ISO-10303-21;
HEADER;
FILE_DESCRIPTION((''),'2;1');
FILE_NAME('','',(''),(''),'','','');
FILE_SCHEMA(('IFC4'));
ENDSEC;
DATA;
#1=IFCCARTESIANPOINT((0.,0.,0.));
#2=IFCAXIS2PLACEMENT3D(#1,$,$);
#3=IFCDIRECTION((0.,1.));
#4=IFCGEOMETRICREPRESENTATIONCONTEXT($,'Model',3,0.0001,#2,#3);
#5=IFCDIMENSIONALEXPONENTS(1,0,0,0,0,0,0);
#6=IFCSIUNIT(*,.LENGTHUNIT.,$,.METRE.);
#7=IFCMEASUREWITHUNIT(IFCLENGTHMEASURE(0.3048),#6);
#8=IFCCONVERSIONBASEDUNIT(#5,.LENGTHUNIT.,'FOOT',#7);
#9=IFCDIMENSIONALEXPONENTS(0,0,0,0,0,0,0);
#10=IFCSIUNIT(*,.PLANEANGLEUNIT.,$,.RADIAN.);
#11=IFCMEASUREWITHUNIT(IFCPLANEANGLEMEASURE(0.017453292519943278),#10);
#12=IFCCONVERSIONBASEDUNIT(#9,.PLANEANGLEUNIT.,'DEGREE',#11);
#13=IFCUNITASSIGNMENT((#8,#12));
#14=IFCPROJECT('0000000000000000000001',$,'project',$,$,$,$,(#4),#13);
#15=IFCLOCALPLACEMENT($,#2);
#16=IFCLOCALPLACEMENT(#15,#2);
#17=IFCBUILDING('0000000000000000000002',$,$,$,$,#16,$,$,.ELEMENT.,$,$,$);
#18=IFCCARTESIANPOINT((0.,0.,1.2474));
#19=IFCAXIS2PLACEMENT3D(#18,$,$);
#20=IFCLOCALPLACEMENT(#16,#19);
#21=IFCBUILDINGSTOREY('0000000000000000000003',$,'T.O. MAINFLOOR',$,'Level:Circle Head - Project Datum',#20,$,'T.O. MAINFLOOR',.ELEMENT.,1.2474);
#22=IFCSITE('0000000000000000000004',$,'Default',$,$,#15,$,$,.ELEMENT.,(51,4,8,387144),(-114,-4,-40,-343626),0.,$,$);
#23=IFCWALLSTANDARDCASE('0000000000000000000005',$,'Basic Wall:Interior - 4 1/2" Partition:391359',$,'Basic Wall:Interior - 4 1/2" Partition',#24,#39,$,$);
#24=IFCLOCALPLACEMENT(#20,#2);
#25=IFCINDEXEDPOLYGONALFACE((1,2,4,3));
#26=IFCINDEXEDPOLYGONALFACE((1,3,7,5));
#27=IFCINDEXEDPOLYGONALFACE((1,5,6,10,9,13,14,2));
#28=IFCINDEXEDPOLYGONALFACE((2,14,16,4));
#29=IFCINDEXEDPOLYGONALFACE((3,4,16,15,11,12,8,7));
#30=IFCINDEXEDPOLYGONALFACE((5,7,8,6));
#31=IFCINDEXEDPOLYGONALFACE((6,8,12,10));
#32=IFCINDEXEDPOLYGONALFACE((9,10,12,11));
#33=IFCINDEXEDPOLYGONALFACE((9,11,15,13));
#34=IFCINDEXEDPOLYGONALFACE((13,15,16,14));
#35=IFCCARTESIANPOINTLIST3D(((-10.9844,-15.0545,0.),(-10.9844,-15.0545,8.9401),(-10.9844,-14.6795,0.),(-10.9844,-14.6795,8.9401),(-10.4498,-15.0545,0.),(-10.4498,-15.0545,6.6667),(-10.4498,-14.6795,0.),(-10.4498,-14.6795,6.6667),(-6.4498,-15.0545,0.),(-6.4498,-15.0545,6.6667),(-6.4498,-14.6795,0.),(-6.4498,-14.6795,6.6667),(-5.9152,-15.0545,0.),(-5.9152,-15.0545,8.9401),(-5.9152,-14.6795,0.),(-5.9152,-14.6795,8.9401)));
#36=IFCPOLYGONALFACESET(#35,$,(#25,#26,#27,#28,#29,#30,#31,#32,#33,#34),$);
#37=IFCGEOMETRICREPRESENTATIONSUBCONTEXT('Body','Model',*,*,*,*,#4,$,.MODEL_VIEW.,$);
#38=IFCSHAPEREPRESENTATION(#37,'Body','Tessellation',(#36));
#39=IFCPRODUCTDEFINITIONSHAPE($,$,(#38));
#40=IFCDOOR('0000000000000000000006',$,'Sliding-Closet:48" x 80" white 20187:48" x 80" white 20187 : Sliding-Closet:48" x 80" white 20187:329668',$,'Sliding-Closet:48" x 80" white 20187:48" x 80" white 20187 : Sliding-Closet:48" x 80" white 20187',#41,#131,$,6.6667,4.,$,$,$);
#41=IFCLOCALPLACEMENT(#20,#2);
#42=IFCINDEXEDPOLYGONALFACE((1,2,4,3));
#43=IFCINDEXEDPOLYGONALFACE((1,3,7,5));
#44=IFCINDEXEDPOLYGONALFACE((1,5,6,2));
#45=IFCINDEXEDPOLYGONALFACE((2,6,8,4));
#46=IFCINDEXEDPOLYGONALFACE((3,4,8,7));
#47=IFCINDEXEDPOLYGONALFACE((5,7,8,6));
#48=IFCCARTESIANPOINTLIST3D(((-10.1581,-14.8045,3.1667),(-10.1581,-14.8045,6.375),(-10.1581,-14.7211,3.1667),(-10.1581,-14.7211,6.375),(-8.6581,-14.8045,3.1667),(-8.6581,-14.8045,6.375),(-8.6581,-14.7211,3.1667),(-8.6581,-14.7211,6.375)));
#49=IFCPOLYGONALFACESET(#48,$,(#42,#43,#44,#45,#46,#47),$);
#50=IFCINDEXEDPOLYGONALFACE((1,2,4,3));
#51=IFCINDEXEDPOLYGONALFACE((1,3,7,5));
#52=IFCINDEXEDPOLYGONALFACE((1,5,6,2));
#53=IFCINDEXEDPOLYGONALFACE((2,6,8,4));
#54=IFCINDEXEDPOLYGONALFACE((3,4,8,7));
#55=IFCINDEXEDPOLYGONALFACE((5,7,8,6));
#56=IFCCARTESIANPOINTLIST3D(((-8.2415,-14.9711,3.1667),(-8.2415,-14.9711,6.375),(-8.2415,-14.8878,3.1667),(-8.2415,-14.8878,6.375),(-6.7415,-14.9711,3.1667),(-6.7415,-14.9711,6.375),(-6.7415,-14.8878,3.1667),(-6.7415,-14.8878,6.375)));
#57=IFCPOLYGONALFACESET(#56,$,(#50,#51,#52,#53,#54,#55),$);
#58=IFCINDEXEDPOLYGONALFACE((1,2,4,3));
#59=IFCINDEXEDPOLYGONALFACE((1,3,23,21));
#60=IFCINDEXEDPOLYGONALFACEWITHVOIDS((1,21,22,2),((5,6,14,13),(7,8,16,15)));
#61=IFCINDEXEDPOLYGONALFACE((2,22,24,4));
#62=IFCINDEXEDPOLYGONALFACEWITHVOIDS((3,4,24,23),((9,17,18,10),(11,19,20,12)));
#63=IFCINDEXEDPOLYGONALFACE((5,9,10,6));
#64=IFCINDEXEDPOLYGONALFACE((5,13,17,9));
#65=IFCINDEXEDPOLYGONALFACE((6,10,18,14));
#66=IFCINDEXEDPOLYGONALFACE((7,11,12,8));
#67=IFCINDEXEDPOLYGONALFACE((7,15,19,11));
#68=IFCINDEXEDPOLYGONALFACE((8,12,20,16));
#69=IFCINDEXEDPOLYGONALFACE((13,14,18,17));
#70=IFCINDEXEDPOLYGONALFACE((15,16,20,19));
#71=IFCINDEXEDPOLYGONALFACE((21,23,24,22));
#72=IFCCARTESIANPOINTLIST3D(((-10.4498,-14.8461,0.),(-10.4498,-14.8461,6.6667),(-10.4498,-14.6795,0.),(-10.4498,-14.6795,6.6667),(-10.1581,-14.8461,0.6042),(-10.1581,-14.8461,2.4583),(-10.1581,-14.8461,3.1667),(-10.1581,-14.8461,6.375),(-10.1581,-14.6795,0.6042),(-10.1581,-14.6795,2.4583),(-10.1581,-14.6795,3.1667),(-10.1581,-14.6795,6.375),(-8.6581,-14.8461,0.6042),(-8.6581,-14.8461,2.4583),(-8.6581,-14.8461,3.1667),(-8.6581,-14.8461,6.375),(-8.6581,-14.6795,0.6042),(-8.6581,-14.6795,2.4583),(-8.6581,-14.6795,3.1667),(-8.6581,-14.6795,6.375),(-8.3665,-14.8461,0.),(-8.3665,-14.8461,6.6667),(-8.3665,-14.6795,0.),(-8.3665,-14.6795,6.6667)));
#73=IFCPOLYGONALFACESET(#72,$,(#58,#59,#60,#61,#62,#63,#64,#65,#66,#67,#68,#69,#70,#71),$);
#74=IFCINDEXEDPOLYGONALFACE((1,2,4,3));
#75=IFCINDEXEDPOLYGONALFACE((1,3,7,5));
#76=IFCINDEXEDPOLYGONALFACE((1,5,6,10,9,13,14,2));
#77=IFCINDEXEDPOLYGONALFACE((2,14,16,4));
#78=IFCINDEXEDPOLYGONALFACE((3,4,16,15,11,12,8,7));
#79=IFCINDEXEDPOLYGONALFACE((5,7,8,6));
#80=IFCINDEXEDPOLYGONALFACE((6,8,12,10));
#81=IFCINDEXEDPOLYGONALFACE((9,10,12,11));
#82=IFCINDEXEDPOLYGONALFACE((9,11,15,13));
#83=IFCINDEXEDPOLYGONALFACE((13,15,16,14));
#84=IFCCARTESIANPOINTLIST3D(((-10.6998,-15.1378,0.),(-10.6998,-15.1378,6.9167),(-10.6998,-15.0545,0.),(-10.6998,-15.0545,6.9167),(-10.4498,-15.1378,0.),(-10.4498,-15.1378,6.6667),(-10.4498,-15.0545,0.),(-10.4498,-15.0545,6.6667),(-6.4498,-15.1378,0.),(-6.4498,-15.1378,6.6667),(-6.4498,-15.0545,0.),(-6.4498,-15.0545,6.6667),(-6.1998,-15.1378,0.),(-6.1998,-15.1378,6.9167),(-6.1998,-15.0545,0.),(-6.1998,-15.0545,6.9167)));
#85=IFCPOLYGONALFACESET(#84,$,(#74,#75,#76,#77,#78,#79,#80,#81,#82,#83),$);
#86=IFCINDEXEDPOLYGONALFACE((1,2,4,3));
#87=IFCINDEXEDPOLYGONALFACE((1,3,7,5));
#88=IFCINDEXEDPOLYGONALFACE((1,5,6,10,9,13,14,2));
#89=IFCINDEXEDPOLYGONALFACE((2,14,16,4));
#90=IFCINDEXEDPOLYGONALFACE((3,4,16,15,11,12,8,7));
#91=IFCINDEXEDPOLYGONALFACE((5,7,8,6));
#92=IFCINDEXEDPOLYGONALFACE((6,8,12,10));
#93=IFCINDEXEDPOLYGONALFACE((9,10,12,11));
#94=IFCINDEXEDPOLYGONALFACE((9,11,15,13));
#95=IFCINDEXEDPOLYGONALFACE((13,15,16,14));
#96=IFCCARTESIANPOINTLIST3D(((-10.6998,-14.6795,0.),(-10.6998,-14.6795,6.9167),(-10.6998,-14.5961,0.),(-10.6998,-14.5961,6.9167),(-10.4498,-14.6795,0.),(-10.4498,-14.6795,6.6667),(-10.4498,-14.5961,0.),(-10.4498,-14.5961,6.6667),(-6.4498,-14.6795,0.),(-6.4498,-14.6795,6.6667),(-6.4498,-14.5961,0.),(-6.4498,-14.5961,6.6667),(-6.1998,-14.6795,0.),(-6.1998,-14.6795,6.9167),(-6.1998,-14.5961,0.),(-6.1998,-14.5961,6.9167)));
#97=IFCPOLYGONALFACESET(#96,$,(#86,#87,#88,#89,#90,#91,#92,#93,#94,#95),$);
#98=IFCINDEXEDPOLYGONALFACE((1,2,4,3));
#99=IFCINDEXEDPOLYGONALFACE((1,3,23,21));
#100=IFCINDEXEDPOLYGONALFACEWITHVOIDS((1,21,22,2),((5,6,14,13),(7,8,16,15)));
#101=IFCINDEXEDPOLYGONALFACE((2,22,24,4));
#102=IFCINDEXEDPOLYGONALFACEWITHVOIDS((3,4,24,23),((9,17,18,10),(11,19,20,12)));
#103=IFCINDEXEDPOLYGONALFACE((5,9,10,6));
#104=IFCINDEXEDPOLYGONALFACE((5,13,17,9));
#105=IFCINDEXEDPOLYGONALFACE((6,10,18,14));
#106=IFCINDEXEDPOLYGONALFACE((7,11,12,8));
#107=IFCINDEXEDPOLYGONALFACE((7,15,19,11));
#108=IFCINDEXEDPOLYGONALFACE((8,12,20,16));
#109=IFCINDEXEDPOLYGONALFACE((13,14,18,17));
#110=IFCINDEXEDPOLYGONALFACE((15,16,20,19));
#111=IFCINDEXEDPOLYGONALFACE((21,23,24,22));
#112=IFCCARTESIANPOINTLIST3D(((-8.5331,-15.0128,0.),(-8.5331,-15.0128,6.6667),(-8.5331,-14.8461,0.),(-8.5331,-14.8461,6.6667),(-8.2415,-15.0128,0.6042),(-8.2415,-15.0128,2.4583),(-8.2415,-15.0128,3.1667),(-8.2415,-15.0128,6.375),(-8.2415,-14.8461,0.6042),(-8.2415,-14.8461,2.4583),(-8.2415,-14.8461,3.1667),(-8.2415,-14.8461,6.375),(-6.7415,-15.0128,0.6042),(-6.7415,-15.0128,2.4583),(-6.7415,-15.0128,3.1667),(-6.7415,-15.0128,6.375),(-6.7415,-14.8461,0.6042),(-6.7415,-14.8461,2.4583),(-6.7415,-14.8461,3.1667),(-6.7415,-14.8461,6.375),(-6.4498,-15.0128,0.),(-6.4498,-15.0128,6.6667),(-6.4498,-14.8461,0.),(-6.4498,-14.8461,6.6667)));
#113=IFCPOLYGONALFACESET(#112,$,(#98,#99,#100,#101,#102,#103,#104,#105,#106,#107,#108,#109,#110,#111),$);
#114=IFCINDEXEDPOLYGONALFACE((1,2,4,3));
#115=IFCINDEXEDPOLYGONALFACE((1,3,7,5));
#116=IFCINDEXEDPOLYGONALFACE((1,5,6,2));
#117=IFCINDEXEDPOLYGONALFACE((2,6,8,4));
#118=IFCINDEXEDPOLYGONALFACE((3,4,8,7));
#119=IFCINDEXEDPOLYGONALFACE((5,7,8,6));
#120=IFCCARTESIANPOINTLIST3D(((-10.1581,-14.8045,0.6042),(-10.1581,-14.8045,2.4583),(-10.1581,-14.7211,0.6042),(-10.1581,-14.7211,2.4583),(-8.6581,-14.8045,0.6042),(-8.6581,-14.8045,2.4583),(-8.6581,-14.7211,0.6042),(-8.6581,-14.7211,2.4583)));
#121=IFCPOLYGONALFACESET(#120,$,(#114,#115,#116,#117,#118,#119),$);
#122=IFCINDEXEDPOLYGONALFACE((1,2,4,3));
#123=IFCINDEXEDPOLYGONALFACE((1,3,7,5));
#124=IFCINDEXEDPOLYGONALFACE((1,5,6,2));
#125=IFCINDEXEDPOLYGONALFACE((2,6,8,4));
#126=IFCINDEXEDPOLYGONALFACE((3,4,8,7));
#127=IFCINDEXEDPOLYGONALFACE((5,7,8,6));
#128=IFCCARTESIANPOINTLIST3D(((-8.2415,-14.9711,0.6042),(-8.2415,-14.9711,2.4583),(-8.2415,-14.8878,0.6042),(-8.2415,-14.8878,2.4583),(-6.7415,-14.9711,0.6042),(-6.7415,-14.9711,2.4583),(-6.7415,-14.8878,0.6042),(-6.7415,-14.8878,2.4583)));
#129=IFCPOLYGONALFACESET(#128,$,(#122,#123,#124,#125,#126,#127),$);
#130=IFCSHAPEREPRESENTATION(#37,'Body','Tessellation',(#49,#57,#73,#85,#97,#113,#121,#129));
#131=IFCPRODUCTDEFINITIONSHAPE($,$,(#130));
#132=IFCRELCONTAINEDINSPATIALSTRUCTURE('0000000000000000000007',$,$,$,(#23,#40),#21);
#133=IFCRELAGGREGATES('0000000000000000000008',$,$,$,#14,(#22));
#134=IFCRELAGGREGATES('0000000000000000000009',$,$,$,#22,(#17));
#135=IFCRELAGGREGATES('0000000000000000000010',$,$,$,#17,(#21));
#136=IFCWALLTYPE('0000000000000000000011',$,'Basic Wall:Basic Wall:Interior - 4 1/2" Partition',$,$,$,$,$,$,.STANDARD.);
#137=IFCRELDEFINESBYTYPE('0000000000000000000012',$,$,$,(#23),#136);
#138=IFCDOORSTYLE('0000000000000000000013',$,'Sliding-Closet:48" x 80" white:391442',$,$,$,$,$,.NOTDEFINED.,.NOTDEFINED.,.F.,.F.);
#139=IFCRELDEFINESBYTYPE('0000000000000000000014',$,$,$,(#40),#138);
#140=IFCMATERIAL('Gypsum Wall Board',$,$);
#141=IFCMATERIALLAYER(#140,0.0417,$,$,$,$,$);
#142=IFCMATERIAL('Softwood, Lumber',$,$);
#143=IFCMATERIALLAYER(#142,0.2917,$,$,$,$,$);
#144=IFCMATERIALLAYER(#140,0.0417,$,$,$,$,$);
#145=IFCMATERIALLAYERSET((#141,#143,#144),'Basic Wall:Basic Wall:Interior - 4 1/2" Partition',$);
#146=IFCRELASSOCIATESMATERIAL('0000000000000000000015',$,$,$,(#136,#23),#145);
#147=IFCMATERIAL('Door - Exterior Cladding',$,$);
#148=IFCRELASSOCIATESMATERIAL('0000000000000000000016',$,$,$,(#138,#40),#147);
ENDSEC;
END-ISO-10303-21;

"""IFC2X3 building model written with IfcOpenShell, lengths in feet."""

from ifc_helpers import new_model, entity, si_unit, converted_unit, direction, frame, frame_2d, origin, place, context, subcontext, project, spatial, polyline, rectangle, outline, extrude, source, transform, mapped, material, layer, layer_set, layer_usage, type_object, type_shapes, element, fill, save


model = new_model("IFC2X3")

# Units and contexts
model_context = context("Model", 3, precision=0.0001, world=origin(), true_north=direction((0.0, 1.0)))
body_context = subcontext(model_context, "Body", "Model", "MODEL_VIEW")
ifc_project = project(units=[converted_unit("LENGTHUNIT", "FOOT", entity("IfcLengthMeasure", 0.3048), si_unit("LENGTHUNIT", "METRE"), dimensions=[1, 0, 0, 0, 0, 0, 0]), converted_unit("PLANEANGLEUNIT", "DEGREE", entity("IfcPlaneAngleMeasure", 0.017453292519943278), si_unit("PLANEANGLEUNIT", "RADIAN"), dimensions=[0, 0, 0, 0, 0, 0, 0])], contexts=[model_context])

# Site, building, storey
site_placement = place(None, origin())
site = spatial("IfcSite", under=ifc_project, at=site_placement, Name="Default", CompositionType="ELEMENT", RefLatitude=(51, 4, 8, 387144), RefLongitude=(-114, -4, -40, -343626), RefElevation=0.0)
building_placement = place(site_placement, origin())
building = spatial("IfcBuilding", under=site, at=building_placement, CompositionType="ELEMENT")
storey_placement = place(building_placement, frame((0.0, 0.0, 1.2474)))
storey = spatial("IfcBuildingStorey", under=building, at=storey_placement, Name="T.O. MAINFLOOR", ObjectType="Level:Circle Head - Project Datum", LongName="T.O. MAINFLOOR", CompositionType="ELEMENT", Elevation=1.2474)

# Shared definitions
ifc_material_1 = material(Name="Gypsum Wall Board")

# Shared definitions
ifc_material_2 = material(Name="Door - Exterior Cladding")

# Shared definitions
ifc_layer_1 = layer(ifc_material_1, 0.0417)
ifc_material_3 = material(Name="Softwood, Lumber")
ifc_layer_2 = layer(ifc_material_3, 0.2917)
ifc_layer_3 = layer(ifc_material_1, 0.0417)
ifc_layer_set_1 = layer_set([ifc_layer_1, ifc_layer_2, ifc_layer_3], Name="Basic Wall:Basic Wall:Interior - 4 1/2\" Partition")
wall_type_1 = type_object("IfcWallType", Name="Basic Wall:Basic Wall:Interior - 4 1/2\" Partition", PredefinedType="STANDARD", material=ifc_layer_set_1)

# Wall, opening, door
ifc_layer_usage_1 = layer_usage(ifc_layer_set_1, "AXIS2", "NEGATIVE", 0.1875)
wall_1_placement = place(storey_placement, frame((-5.9152, -14.867, 0.0), z_axis=(0.0, 0.0, 1.0), x_axis=(-1.0, 0.0, 0.0)))
wall_1 = element("IfcWallStandardCase", 1, at=wall_1_placement, inside=storey, type_object=wall_type_1, material=ifc_layer_usage_1, Name="Basic Wall:Interior - 4 1/2\" Partition:391359", ObjectType="Basic Wall:Interior - 4 1/2\" Partition", context=body_context, shape_type="SweptSolid", body=[
    extrude(rectangle(XDim=5.0692, YDim=0.375, at=frame_2d((2.5346, 0.0), x_axis=(1.0, 0.0))), origin(), (0.0, 0.0, 1.0), 8.9401),
])
opening_1_placement = place(wall_1_placement, frame((-5.9152, -14.867, 0.0), z_axis=(0.0, 0.0, 1.0), x_axis=(-1.0, 0.0, 0.0)))
opening_1 = element("IfcOpeningElement", 2, at=opening_1_placement, cuts=wall_1, ObjectType="Opening", context=body_context, shape_type="SweptSolid", body=[
    extrude(rectangle(XDim=6.6667, YDim=4.0, at=frame_2d((0.0, 0.0), x_axis=(1.0, 0.0))), frame((-8.4498, -14.6757, 3.3333), z_axis=(0.0, -1.0, 0.0), x_axis=(0.0, 0.0, 1.0)), (0.0, 0.0, 1.0), 0.3825),
])
door_style_1 = type_object("IfcDoorStyle", Name="Sliding-Closet:48\" x 80\" white:391442", ConstructionType="NOTDEFINED", OperationType="NOTDEFINED", ParameterTakesPrecedence=False, Sizeable=False, material=ifc_material_2)
shared_shape_1 = source(origin(), body_context, "Body", "SweptSolid", [
    extrude(rectangle(XDim=1.5, YDim=0.0833, at=frame_2d((0.0, 0.0), x_axis=(1.0, 0.0))), frame((1.0417, 0.2954, 3.1667), z_axis=(0.0, 0.0, 1.0), x_axis=(-1.0, 0.0, 0.0)), (0.0, 0.0, 1.0), 3.2083),
    extrude(rectangle(XDim=1.5, YDim=0.0833, at=frame_2d((0.0, 0.0), x_axis=(1.0, 0.0))), frame((2.9583, 0.1287, 3.1667)), (0.0, 0.0, 1.0), 3.2083),
    extrude(outline(polyline([(-1.0417, -3.3333), (1.0417, -3.3333), (1.0417, 3.3333), (-1.0417, 3.3333), (-1.0417, -3.3333)]), holes=[polyline([(-0.75, -2.7292), (-0.75, -0.875), (0.75, -0.875), (0.75, -2.7292), (-0.75, -2.7292)]), polyline([(-0.75, -0.1667), (-0.75, 3.0417), (0.75, 3.0417), (0.75, -0.1667), (-0.75, -0.1667)])]), frame((1.0417, 0.2121, 3.3333), z_axis=(0.0, 1.0, 0.0), x_axis=(-1.0, 0.0, 0.0)), (0.0, 0.0, 1.0), 0.1667),
    extrude(outline(polyline([(-2.25, -3.5208), (2.25, -3.5208), (2.25, 3.3958), (2.0, 3.3958), (2.0, -3.2708), (-2.0, -3.2708), (-2.0, 3.3958), (-2.25, 3.3958), (-2.25, -3.5208)])), frame((2.0, -0.0796, 3.3958), z_axis=(0.0, 1.0, 0.0), x_axis=(1.0, 0.0, 0.0)), (0.0, 0.0, 1.0), 0.0833),
    extrude(outline(polyline([(-3.3958, -2.0), (-3.3958, -2.25), (3.5208, -2.25), (3.5208, 2.25), (-3.3958, 2.25), (-3.3958, 2.0), (3.2708, 2.0), (3.2708, -2.0), (-3.3958, -2.0)])), frame((2.0, 0.3788, 3.3958), z_axis=(0.0, -1.0, 0.0), x_axis=(0.0, 0.0, 1.0)), (0.0, 0.0, -1.0), 0.0833),
    extrude(outline(polyline([(-3.3333, -1.0417), (3.3333, -1.0417), (3.3333, 1.0417), (-3.3333, 1.0417), (-3.3333, -1.0417)]), holes=[polyline([(-3.0417, -0.75), (-3.0417, 0.75), (0.1667, 0.75), (0.1667, -0.75), (-3.0417, -0.75)]), polyline([(0.875, -0.75), (0.875, 0.75), (2.7292, 0.75), (2.7292, -0.75), (0.875, -0.75)])]), frame((2.9583, 0.0454, 3.3333), z_axis=(0.0, 1.0, 0.0), x_axis=(0.0, 0.0, -1.0)), (0.0, 0.0, 1.0), 0.1667),
    extrude(rectangle(XDim=1.5, YDim=0.0833, at=frame_2d((0.0, 0.0), x_axis=(1.0, 0.0))), frame((1.0417, 0.2954, 0.6042), z_axis=(0.0, 0.0, 1.0), x_axis=(-1.0, 0.0, 0.0)), (0.0, 0.0, 1.0), 1.8542),
    extrude(rectangle(XDim=1.5, YDim=0.0833, at=frame_2d((0.0, 0.0), x_axis=(1.0, 0.0))), frame((2.9583, 0.1287, 0.6042)), (0.0, 0.0, 1.0), 1.8542),
])
type_shapes(door_style_1, [shared_shape_1])
door_1_placement = place(opening_1_placement, frame((-10.4498, -15.0582, 0.0)))
door_1 = element("IfcDoor", 3, at=door_1_placement, inside=storey, type_object=door_style_1, material=ifc_material_2, Name="Sliding-Closet:48\" x 80\" white 20187:48\" x 80\" white 20187 : Sliding-Closet:48\" x 80\" white 20187:329668", ObjectType="Sliding-Closet:48\" x 80\" white 20187:48\" x 80\" white 20187 : Sliding-Closet:48\" x 80\" white 20187", OverallHeight=6.6667, OverallWidth=4.0, context=body_context, shape_type="MappedRepresentation", body=[
    mapped(shared_shape_1, transform((0.0, 0.0, 0.0), scale=1.0)),
])
fill(opening_1, door_1)

save(model, "model.ifc")
